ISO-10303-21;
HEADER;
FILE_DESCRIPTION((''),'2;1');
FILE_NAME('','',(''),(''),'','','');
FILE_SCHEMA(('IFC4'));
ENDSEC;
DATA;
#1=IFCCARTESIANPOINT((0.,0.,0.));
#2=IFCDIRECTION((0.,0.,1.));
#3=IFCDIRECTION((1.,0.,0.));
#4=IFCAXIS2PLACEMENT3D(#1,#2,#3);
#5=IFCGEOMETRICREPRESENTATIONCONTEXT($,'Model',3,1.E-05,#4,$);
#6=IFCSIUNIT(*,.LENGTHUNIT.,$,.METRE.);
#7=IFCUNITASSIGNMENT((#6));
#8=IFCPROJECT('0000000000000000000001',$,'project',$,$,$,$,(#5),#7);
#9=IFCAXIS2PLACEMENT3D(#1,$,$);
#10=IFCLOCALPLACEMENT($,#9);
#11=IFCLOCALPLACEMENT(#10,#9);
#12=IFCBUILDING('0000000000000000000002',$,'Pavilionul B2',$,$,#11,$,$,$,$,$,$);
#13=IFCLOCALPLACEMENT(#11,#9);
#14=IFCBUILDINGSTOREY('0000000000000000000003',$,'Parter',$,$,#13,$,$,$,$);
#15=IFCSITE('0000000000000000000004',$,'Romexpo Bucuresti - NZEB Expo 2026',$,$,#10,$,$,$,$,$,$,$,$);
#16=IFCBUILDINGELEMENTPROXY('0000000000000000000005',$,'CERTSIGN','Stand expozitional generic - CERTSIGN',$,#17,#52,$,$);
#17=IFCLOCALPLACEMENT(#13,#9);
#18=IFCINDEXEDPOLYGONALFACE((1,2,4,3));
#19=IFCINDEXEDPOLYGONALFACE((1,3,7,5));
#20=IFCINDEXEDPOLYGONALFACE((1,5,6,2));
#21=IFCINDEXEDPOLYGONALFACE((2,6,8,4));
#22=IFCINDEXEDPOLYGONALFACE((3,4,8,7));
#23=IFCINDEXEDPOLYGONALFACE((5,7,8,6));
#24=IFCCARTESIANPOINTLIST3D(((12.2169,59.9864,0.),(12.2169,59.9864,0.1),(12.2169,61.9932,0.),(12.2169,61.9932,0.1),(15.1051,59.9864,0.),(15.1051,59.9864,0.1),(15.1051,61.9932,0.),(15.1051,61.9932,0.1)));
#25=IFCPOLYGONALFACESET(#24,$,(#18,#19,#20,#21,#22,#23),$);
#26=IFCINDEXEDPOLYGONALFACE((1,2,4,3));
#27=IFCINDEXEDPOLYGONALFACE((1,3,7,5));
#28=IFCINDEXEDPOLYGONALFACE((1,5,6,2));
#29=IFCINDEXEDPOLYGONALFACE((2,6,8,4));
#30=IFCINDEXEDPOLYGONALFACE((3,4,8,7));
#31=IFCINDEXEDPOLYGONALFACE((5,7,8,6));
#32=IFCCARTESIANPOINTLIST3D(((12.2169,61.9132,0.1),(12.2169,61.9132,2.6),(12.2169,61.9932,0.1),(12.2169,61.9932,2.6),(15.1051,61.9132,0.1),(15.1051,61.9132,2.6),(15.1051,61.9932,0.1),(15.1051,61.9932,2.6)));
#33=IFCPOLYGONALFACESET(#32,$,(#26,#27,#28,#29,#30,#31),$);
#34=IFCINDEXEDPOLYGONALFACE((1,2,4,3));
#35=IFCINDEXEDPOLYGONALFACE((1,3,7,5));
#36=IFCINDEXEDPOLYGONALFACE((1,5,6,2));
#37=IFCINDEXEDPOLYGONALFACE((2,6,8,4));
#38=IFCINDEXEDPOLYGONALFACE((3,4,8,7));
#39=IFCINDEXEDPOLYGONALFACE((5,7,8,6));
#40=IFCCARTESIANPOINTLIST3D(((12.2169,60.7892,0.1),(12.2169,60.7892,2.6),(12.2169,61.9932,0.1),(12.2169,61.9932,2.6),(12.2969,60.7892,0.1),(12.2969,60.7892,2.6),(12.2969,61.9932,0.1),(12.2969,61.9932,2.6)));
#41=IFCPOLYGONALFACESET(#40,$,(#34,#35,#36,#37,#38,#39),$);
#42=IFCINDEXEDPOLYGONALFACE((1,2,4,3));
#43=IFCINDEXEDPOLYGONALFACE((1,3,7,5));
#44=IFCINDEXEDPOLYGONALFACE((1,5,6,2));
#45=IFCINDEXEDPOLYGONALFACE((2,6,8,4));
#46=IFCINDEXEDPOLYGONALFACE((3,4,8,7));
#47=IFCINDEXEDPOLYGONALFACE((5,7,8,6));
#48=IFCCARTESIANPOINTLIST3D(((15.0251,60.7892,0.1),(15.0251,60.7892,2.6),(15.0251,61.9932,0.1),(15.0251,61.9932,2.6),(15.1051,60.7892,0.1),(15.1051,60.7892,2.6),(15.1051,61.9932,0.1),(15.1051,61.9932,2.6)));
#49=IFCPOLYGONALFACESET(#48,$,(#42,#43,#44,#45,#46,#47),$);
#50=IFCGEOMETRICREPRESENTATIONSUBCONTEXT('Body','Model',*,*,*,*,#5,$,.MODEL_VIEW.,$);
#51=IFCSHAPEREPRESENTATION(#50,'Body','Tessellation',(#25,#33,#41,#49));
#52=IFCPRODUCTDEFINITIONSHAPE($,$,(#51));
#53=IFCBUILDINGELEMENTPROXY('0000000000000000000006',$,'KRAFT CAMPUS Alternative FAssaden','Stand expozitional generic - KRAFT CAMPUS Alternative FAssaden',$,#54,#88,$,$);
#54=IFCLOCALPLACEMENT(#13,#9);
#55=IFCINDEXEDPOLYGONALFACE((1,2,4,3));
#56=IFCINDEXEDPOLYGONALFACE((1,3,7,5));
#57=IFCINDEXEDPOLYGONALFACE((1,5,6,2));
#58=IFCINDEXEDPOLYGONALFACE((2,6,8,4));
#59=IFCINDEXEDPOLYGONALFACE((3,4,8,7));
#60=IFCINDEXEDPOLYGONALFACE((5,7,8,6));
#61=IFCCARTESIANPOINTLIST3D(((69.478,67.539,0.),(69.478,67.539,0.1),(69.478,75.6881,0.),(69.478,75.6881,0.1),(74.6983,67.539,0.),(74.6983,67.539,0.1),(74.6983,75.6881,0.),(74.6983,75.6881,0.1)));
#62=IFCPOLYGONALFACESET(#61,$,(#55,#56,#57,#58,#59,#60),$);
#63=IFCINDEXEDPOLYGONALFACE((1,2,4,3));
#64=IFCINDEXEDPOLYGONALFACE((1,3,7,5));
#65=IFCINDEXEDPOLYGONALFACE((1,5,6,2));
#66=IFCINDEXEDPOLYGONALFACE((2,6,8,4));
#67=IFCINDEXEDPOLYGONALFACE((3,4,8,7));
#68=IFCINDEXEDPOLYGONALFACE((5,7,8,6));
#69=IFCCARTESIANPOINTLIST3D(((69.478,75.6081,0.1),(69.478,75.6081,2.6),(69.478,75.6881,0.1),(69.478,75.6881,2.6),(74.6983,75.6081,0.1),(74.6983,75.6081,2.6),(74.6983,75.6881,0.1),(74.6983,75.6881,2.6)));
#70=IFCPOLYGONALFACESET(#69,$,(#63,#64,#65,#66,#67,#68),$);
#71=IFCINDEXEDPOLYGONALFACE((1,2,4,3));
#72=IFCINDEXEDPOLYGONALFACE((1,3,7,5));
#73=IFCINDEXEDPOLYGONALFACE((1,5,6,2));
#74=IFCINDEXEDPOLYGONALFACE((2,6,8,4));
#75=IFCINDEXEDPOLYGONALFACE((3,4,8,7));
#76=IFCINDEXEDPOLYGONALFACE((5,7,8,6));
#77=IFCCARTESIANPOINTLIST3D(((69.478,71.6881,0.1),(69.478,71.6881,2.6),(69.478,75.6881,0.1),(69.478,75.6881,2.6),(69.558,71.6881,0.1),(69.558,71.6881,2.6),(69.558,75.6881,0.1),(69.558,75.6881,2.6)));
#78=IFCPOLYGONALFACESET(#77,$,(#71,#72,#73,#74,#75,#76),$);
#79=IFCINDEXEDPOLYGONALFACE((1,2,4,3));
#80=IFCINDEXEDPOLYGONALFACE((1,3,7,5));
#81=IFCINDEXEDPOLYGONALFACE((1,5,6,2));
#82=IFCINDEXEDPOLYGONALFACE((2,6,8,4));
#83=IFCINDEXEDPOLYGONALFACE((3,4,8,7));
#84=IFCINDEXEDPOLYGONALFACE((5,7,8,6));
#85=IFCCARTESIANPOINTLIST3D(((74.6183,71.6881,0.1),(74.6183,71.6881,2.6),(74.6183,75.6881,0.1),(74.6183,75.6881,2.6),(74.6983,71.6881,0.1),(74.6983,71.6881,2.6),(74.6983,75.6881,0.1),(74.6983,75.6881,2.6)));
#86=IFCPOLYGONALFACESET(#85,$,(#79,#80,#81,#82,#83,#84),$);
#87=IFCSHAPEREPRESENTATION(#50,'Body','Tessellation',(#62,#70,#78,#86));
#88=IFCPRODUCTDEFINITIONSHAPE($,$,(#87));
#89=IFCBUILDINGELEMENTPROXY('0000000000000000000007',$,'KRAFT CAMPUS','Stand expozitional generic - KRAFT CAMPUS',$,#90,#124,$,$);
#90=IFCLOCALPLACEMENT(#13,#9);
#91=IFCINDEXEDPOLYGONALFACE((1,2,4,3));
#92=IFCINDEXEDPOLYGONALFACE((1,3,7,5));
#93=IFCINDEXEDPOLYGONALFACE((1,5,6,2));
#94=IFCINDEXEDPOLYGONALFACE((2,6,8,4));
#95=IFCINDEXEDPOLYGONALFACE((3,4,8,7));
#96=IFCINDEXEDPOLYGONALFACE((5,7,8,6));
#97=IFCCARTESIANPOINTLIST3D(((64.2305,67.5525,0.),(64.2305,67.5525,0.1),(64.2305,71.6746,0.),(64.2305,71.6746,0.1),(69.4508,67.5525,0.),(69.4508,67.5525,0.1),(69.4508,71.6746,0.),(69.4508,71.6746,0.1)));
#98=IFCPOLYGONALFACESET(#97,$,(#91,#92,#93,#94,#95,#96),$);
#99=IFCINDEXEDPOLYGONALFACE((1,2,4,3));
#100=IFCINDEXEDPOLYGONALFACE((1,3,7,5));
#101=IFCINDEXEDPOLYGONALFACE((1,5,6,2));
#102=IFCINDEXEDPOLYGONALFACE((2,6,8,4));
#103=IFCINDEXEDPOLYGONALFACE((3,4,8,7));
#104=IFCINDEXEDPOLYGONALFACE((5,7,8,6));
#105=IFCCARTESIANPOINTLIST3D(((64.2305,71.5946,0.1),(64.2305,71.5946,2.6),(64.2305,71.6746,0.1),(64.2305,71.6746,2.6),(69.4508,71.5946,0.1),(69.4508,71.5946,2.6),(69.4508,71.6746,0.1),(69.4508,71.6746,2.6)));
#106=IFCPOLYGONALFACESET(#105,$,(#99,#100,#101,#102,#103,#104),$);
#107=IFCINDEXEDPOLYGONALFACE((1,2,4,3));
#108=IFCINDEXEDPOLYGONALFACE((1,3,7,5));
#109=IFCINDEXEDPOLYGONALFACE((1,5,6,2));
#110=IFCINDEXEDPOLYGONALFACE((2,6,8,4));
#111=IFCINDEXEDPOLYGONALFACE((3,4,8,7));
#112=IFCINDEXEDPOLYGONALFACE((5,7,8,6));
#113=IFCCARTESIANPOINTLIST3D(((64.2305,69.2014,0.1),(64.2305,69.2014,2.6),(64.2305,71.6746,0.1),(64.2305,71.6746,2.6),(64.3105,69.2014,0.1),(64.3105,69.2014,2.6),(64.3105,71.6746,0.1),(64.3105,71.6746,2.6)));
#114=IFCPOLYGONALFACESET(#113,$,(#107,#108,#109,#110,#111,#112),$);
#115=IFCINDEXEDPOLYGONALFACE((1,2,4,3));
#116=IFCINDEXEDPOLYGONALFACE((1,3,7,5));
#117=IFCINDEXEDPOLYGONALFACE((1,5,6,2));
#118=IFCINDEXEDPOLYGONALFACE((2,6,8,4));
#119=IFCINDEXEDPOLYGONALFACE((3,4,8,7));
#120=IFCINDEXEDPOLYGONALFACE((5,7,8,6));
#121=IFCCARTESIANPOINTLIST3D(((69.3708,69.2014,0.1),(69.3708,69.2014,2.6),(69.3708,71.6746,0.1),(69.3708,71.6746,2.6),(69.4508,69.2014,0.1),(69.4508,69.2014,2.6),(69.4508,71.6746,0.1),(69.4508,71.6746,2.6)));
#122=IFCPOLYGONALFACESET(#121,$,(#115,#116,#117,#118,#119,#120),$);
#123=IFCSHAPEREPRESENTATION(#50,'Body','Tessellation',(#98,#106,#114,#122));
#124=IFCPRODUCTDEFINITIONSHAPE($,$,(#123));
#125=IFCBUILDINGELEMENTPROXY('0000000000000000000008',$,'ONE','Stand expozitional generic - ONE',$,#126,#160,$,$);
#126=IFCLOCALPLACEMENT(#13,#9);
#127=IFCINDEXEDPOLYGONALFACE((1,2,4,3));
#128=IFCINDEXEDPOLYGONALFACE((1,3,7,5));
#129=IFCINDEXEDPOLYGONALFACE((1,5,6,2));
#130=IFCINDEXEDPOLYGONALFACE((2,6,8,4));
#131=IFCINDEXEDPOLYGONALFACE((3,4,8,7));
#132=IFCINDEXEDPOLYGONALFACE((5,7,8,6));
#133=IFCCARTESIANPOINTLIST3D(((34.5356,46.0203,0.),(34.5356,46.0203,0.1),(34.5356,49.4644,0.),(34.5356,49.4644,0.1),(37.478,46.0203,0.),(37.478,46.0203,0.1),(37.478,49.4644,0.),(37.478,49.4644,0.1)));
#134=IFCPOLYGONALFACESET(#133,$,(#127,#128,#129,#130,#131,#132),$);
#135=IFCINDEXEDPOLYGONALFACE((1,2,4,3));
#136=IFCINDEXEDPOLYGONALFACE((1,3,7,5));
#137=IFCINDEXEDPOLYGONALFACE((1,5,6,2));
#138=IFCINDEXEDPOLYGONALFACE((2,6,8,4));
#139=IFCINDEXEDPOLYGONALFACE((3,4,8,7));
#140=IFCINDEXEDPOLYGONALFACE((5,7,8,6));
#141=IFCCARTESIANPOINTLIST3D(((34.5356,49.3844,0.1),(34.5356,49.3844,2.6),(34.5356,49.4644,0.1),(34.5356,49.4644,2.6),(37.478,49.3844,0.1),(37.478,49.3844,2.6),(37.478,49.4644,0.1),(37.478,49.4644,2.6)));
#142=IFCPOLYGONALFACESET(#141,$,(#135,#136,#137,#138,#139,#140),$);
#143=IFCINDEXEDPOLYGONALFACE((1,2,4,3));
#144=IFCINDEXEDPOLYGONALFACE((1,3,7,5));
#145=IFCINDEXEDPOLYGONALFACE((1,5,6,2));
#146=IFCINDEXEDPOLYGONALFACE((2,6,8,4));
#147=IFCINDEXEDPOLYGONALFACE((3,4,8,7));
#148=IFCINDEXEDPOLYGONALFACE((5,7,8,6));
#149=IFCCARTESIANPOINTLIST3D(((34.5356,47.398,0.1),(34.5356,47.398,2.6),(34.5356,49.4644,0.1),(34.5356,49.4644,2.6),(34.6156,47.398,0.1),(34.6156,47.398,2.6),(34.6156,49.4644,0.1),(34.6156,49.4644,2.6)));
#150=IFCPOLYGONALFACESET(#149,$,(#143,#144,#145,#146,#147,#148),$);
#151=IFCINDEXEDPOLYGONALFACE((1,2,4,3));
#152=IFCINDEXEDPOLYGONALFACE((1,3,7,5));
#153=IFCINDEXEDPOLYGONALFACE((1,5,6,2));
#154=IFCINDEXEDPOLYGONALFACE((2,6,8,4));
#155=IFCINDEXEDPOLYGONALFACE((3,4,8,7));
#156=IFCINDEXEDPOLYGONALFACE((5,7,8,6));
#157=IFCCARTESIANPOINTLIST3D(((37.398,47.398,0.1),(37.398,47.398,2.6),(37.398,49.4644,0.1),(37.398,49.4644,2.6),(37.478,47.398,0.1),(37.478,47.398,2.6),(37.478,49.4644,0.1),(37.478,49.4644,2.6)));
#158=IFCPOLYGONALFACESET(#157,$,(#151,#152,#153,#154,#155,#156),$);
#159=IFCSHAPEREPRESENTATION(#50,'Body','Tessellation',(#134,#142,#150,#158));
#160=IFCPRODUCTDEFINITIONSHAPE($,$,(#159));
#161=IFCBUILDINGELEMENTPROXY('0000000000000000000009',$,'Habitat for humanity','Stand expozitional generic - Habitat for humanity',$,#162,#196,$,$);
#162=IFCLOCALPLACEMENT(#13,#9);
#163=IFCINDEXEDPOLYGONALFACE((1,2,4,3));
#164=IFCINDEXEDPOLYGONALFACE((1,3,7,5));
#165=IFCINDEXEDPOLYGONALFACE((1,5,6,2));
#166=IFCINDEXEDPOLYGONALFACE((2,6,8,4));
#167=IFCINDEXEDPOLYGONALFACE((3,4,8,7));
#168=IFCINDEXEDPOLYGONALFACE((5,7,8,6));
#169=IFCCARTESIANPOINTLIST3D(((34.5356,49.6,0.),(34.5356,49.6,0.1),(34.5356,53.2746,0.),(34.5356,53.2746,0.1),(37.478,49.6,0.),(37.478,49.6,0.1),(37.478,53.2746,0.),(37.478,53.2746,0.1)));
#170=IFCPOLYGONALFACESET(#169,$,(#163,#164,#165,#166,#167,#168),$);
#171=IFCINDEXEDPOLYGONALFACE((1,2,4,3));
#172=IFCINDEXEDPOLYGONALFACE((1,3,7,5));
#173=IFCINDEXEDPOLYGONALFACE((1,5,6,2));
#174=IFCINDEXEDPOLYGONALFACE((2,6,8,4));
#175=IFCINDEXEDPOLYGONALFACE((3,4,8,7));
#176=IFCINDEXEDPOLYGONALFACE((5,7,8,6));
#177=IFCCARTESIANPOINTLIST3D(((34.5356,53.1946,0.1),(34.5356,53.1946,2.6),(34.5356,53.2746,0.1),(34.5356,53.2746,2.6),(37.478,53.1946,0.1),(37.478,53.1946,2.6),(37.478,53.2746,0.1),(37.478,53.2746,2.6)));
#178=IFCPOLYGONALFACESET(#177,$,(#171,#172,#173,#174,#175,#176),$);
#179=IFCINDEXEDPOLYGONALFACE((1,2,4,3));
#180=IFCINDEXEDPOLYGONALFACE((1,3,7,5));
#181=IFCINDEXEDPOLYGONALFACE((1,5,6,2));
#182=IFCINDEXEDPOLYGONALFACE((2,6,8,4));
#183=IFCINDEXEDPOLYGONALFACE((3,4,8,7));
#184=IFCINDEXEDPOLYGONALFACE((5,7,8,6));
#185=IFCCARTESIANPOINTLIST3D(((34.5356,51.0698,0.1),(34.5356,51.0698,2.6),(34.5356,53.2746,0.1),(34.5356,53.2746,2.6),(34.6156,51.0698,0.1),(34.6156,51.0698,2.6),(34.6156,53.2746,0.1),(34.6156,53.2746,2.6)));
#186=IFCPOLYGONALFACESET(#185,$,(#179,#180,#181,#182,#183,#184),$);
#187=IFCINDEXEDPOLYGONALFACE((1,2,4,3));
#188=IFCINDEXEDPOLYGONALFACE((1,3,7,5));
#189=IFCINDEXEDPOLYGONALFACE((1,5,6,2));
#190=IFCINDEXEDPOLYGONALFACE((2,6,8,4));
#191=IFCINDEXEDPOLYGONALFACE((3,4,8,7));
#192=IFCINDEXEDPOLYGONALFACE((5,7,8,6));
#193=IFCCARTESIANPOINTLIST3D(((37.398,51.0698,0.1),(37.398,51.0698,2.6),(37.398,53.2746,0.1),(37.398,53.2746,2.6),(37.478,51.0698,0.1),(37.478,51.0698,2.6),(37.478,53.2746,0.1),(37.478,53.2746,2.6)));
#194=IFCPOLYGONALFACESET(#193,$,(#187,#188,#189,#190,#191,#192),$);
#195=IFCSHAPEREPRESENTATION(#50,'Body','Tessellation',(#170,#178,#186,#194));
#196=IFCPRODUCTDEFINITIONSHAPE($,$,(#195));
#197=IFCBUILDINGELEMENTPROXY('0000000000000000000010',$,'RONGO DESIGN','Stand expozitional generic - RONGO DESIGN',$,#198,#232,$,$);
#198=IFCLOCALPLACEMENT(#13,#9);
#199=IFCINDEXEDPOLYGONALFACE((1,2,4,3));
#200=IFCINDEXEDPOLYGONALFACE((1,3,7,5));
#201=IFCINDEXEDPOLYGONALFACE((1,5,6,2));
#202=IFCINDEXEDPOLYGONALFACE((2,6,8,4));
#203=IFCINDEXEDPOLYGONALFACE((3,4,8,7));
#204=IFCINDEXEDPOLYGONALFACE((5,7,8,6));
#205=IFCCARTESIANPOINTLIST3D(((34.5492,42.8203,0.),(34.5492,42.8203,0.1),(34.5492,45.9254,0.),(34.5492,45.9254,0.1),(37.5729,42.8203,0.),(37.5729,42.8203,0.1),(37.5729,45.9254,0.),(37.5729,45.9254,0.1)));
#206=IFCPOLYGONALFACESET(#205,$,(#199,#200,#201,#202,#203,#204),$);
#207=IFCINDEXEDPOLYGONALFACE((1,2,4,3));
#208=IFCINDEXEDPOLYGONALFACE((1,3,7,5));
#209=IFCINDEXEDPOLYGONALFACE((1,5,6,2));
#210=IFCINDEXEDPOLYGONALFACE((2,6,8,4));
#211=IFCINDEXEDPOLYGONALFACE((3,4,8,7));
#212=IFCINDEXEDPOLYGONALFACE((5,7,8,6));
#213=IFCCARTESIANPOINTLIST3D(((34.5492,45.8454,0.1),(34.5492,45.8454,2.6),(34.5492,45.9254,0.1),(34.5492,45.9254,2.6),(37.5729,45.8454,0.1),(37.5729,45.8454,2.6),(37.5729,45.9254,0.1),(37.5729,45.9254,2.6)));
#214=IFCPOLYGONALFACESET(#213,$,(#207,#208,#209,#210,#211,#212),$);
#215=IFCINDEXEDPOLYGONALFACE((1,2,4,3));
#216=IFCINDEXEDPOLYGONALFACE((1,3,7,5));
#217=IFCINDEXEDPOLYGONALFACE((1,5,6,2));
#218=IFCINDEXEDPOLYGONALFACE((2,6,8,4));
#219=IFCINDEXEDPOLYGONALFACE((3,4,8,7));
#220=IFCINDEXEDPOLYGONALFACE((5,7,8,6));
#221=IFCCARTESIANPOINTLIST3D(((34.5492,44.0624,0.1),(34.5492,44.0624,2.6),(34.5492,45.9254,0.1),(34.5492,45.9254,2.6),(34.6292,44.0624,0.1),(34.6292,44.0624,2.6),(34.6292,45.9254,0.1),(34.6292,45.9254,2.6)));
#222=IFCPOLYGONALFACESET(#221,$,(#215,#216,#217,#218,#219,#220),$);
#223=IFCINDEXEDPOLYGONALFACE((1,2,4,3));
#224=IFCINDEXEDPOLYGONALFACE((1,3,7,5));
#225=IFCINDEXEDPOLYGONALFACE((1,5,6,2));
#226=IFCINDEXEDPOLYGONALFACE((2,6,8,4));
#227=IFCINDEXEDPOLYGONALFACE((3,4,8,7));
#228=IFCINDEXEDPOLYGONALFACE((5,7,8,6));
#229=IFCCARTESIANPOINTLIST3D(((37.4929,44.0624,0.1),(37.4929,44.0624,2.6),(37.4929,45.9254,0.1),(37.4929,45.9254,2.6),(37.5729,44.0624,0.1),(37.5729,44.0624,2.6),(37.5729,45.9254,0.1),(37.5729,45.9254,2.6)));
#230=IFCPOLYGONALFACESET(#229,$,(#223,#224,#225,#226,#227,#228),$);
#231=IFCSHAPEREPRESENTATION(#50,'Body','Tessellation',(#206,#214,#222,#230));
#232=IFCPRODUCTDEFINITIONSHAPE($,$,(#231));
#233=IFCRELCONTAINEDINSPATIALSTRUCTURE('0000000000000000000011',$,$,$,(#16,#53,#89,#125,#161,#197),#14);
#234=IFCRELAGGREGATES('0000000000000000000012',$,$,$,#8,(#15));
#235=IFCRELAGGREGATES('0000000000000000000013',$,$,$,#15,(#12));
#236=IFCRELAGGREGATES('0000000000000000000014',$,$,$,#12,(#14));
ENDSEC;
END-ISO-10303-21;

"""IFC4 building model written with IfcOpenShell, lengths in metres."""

from ifc_helpers import new_model, si_unit, frame, frame_2d, origin, origin_with_axes, place, context, subcontext, project, spatial, rectangle, extrude, element, save


model = new_model("IFC4")

# Units and contexts
model_context = context("Model", 3, precision=1e-05, world=origin_with_axes())
body_context = subcontext(model_context, "Body", "Model", "MODEL_VIEW")
ifc_project = project(units=[si_unit("LENGTHUNIT", "METRE")], contexts=[model_context])

# Site, building, storey
site_placement = place(None, origin())
site = spatial("IfcSite", under=ifc_project, at=site_placement, Name="Romexpo Bucuresti - NZEB Expo 2026")
building_placement = place(site_placement, origin())
building = spatial("IfcBuilding", under=site, at=building_placement, Name="Pavilionul B2")
storey_placement = place(building_placement, origin())
storey = spatial("IfcBuildingStorey", under=building, at=storey_placement, Name="Parter")

# Building element proxies
proxy_1_placement = place(storey_placement, frame((12.2169, 59.9864, 0.0), z_axis=(0.0, 0.0, 1.0), x_axis=(1.0, 0.0, 0.0)))
element("IfcBuildingElementProxy", 1, at=proxy_1_placement, inside=storey, Name="CERTSIGN", Description="Stand expozitional generic - CERTSIGN", context=body_context, shape_type="SweptSolid", body=[
    extrude(rectangle(XDim=2.8881, YDim=2.0068, at=frame_2d((1.4441, 1.0034))), origin(), (0.0, 0.0, 1.0), 0.1),
    extrude(rectangle(XDim=2.8881, YDim=0.08, at=frame_2d((1.4441, 1.9668))), frame((0.0, 0.0, 0.1)), (0.0, 0.0, 1.0), 2.5),
    extrude(rectangle(XDim=0.08, YDim=1.2041, at=frame_2d((0.04, 1.4047))), frame((0.0, 0.0, 0.1)), (0.0, 0.0, 1.0), 2.5),
    extrude(rectangle(XDim=0.08, YDim=1.2041, at=frame_2d((2.8481, 1.4047))), frame((0.0, 0.0, 0.1)), (0.0, 0.0, 1.0), 2.5),
])
proxy_2_placement = place(storey_placement, frame((69.478, 67.539, 0.0), z_axis=(0.0, 0.0, 1.0), x_axis=(1.0, 0.0, 0.0)))
element("IfcBuildingElementProxy", 2, at=proxy_2_placement, inside=storey, Name="KRAFT CAMPUS Alternative FAssaden", Description="Stand expozitional generic - KRAFT CAMPUS Alternative FAssaden", context=body_context, shape_type="SweptSolid", body=[
    extrude(rectangle(XDim=5.2203, YDim=8.1492, at=frame_2d((2.6102, 4.0746))), origin(), (0.0, 0.0, 1.0), 0.1),
    extrude(rectangle(XDim=5.2203, YDim=0.08, at=frame_2d((2.6102, 8.1092))), frame((0.0, 0.0, 0.1)), (0.0, 0.0, 1.0), 2.5),
    extrude(rectangle(XDim=0.08, YDim=4.0, at=frame_2d((0.04, 6.1492))), frame((0.0, 0.0, 0.1)), (0.0, 0.0, 1.0), 2.5),
    extrude(rectangle(XDim=0.08, YDim=4.0, at=frame_2d((5.1803, 6.1492))), frame((0.0, 0.0, 0.1)), (0.0, 0.0, 1.0), 2.5),
])
proxy_3_placement = place(storey_placement, frame((64.2305, 67.5525, 0.0), z_axis=(0.0, 0.0, 1.0), x_axis=(1.0, 0.0, 0.0)))
element("IfcBuildingElementProxy", 3, at=proxy_3_placement, inside=storey, Name="KRAFT CAMPUS", Description="Stand expozitional generic - KRAFT CAMPUS", context=body_context, shape_type="SweptSolid", body=[
    extrude(rectangle(XDim=5.2203, YDim=4.122, at=frame_2d((2.6102, 2.061))), origin(), (0.0, 0.0, 1.0), 0.1),
    extrude(rectangle(XDim=5.2203, YDim=0.08, at=frame_2d((2.6102, 4.082))), frame((0.0, 0.0, 0.1)), (0.0, 0.0, 1.0), 2.5),
    extrude(rectangle(XDim=0.08, YDim=2.4732, at=frame_2d((0.04, 2.8854))), frame((0.0, 0.0, 0.1)), (0.0, 0.0, 1.0), 2.5),
    extrude(rectangle(XDim=0.08, YDim=2.4732, at=frame_2d((5.1803, 2.8854))), frame((0.0, 0.0, 0.1)), (0.0, 0.0, 1.0), 2.5),
])
proxy_4_placement = place(storey_placement, frame((34.5356, 46.0203, 0.0), z_axis=(0.0, 0.0, 1.0), x_axis=(1.0, 0.0, 0.0)))
element("IfcBuildingElementProxy", 4, at=proxy_4_placement, inside=storey, Name="ONE", Description="Stand expozitional generic - ONE", context=body_context, shape_type="SweptSolid", body=[
    extrude(rectangle(XDim=2.9424, YDim=3.4441, at=frame_2d((1.4712, 1.722))), origin(), (0.0, 0.0, 1.0), 0.1),
    extrude(rectangle(XDim=2.9424, YDim=0.08, at=frame_2d((1.4712, 3.4041))), frame((0.0, 0.0, 0.1)), (0.0, 0.0, 1.0), 2.5),
    extrude(rectangle(XDim=0.08, YDim=2.0664, at=frame_2d((0.04, 2.4108))), frame((0.0, 0.0, 0.1)), (0.0, 0.0, 1.0), 2.5),
    extrude(rectangle(XDim=0.08, YDim=2.0664, at=frame_2d((2.9024, 2.4108))), frame((0.0, 0.0, 0.1)), (0.0, 0.0, 1.0), 2.5),
])
proxy_5_placement = place(storey_placement, frame((34.5356, 49.6, 0.0), z_axis=(0.0, 0.0, 1.0), x_axis=(1.0, 0.0, 0.0)))
element("IfcBuildingElementProxy", 5, at=proxy_5_placement, inside=storey, Name="Habitat for humanity", Description="Stand expozitional generic - Habitat for humanity", context=body_context, shape_type="SweptSolid", body=[
    extrude(rectangle(XDim=2.9424, YDim=3.6746, at=frame_2d((1.4712, 1.8373))), origin(), (0.0, 0.0, 1.0), 0.1),
    extrude(rectangle(XDim=2.9424, YDim=0.08, at=frame_2d((1.4712, 3.6346))), frame((0.0, 0.0, 0.1)), (0.0, 0.0, 1.0), 2.5),
    extrude(rectangle(XDim=0.08, YDim=2.2047, at=frame_2d((0.04, 2.5722))), frame((0.0, 0.0, 0.1)), (0.0, 0.0, 1.0), 2.5),
    extrude(rectangle(XDim=0.08, YDim=2.2047, at=frame_2d((2.9024, 2.5722))), frame((0.0, 0.0, 0.1)), (0.0, 0.0, 1.0), 2.5),
])
proxy_6_placement = place(storey_placement, frame((34.5492, 42.8203, 0.0), z_axis=(0.0, 0.0, 1.0), x_axis=(1.0, 0.0, 0.0)))
element("IfcBuildingElementProxy", 6, at=proxy_6_placement, inside=storey, Name="RONGO DESIGN", Description="Stand expozitional generic - RONGO DESIGN", context=body_context, shape_type="SweptSolid", body=[
    extrude(rectangle(XDim=3.0237, YDim=3.1051, at=frame_2d((1.5119, 1.5525))), origin(), (0.0, 0.0, 1.0), 0.1),
    extrude(rectangle(XDim=3.0237, YDim=0.08, at=frame_2d((1.5119, 3.0651))), frame((0.0, 0.0, 0.1)), (0.0, 0.0, 1.0), 2.5),
    extrude(rectangle(XDim=0.08, YDim=1.8631, at=frame_2d((0.04, 2.1736))), frame((0.0, 0.0, 0.1)), (0.0, 0.0, 1.0), 2.5),
    extrude(rectangle(XDim=0.08, YDim=1.8631, at=frame_2d((2.9837, 2.1736))), frame((0.0, 0.0, 0.1)), (0.0, 0.0, 1.0), 2.5),
])

save(model, "model.ifc")
